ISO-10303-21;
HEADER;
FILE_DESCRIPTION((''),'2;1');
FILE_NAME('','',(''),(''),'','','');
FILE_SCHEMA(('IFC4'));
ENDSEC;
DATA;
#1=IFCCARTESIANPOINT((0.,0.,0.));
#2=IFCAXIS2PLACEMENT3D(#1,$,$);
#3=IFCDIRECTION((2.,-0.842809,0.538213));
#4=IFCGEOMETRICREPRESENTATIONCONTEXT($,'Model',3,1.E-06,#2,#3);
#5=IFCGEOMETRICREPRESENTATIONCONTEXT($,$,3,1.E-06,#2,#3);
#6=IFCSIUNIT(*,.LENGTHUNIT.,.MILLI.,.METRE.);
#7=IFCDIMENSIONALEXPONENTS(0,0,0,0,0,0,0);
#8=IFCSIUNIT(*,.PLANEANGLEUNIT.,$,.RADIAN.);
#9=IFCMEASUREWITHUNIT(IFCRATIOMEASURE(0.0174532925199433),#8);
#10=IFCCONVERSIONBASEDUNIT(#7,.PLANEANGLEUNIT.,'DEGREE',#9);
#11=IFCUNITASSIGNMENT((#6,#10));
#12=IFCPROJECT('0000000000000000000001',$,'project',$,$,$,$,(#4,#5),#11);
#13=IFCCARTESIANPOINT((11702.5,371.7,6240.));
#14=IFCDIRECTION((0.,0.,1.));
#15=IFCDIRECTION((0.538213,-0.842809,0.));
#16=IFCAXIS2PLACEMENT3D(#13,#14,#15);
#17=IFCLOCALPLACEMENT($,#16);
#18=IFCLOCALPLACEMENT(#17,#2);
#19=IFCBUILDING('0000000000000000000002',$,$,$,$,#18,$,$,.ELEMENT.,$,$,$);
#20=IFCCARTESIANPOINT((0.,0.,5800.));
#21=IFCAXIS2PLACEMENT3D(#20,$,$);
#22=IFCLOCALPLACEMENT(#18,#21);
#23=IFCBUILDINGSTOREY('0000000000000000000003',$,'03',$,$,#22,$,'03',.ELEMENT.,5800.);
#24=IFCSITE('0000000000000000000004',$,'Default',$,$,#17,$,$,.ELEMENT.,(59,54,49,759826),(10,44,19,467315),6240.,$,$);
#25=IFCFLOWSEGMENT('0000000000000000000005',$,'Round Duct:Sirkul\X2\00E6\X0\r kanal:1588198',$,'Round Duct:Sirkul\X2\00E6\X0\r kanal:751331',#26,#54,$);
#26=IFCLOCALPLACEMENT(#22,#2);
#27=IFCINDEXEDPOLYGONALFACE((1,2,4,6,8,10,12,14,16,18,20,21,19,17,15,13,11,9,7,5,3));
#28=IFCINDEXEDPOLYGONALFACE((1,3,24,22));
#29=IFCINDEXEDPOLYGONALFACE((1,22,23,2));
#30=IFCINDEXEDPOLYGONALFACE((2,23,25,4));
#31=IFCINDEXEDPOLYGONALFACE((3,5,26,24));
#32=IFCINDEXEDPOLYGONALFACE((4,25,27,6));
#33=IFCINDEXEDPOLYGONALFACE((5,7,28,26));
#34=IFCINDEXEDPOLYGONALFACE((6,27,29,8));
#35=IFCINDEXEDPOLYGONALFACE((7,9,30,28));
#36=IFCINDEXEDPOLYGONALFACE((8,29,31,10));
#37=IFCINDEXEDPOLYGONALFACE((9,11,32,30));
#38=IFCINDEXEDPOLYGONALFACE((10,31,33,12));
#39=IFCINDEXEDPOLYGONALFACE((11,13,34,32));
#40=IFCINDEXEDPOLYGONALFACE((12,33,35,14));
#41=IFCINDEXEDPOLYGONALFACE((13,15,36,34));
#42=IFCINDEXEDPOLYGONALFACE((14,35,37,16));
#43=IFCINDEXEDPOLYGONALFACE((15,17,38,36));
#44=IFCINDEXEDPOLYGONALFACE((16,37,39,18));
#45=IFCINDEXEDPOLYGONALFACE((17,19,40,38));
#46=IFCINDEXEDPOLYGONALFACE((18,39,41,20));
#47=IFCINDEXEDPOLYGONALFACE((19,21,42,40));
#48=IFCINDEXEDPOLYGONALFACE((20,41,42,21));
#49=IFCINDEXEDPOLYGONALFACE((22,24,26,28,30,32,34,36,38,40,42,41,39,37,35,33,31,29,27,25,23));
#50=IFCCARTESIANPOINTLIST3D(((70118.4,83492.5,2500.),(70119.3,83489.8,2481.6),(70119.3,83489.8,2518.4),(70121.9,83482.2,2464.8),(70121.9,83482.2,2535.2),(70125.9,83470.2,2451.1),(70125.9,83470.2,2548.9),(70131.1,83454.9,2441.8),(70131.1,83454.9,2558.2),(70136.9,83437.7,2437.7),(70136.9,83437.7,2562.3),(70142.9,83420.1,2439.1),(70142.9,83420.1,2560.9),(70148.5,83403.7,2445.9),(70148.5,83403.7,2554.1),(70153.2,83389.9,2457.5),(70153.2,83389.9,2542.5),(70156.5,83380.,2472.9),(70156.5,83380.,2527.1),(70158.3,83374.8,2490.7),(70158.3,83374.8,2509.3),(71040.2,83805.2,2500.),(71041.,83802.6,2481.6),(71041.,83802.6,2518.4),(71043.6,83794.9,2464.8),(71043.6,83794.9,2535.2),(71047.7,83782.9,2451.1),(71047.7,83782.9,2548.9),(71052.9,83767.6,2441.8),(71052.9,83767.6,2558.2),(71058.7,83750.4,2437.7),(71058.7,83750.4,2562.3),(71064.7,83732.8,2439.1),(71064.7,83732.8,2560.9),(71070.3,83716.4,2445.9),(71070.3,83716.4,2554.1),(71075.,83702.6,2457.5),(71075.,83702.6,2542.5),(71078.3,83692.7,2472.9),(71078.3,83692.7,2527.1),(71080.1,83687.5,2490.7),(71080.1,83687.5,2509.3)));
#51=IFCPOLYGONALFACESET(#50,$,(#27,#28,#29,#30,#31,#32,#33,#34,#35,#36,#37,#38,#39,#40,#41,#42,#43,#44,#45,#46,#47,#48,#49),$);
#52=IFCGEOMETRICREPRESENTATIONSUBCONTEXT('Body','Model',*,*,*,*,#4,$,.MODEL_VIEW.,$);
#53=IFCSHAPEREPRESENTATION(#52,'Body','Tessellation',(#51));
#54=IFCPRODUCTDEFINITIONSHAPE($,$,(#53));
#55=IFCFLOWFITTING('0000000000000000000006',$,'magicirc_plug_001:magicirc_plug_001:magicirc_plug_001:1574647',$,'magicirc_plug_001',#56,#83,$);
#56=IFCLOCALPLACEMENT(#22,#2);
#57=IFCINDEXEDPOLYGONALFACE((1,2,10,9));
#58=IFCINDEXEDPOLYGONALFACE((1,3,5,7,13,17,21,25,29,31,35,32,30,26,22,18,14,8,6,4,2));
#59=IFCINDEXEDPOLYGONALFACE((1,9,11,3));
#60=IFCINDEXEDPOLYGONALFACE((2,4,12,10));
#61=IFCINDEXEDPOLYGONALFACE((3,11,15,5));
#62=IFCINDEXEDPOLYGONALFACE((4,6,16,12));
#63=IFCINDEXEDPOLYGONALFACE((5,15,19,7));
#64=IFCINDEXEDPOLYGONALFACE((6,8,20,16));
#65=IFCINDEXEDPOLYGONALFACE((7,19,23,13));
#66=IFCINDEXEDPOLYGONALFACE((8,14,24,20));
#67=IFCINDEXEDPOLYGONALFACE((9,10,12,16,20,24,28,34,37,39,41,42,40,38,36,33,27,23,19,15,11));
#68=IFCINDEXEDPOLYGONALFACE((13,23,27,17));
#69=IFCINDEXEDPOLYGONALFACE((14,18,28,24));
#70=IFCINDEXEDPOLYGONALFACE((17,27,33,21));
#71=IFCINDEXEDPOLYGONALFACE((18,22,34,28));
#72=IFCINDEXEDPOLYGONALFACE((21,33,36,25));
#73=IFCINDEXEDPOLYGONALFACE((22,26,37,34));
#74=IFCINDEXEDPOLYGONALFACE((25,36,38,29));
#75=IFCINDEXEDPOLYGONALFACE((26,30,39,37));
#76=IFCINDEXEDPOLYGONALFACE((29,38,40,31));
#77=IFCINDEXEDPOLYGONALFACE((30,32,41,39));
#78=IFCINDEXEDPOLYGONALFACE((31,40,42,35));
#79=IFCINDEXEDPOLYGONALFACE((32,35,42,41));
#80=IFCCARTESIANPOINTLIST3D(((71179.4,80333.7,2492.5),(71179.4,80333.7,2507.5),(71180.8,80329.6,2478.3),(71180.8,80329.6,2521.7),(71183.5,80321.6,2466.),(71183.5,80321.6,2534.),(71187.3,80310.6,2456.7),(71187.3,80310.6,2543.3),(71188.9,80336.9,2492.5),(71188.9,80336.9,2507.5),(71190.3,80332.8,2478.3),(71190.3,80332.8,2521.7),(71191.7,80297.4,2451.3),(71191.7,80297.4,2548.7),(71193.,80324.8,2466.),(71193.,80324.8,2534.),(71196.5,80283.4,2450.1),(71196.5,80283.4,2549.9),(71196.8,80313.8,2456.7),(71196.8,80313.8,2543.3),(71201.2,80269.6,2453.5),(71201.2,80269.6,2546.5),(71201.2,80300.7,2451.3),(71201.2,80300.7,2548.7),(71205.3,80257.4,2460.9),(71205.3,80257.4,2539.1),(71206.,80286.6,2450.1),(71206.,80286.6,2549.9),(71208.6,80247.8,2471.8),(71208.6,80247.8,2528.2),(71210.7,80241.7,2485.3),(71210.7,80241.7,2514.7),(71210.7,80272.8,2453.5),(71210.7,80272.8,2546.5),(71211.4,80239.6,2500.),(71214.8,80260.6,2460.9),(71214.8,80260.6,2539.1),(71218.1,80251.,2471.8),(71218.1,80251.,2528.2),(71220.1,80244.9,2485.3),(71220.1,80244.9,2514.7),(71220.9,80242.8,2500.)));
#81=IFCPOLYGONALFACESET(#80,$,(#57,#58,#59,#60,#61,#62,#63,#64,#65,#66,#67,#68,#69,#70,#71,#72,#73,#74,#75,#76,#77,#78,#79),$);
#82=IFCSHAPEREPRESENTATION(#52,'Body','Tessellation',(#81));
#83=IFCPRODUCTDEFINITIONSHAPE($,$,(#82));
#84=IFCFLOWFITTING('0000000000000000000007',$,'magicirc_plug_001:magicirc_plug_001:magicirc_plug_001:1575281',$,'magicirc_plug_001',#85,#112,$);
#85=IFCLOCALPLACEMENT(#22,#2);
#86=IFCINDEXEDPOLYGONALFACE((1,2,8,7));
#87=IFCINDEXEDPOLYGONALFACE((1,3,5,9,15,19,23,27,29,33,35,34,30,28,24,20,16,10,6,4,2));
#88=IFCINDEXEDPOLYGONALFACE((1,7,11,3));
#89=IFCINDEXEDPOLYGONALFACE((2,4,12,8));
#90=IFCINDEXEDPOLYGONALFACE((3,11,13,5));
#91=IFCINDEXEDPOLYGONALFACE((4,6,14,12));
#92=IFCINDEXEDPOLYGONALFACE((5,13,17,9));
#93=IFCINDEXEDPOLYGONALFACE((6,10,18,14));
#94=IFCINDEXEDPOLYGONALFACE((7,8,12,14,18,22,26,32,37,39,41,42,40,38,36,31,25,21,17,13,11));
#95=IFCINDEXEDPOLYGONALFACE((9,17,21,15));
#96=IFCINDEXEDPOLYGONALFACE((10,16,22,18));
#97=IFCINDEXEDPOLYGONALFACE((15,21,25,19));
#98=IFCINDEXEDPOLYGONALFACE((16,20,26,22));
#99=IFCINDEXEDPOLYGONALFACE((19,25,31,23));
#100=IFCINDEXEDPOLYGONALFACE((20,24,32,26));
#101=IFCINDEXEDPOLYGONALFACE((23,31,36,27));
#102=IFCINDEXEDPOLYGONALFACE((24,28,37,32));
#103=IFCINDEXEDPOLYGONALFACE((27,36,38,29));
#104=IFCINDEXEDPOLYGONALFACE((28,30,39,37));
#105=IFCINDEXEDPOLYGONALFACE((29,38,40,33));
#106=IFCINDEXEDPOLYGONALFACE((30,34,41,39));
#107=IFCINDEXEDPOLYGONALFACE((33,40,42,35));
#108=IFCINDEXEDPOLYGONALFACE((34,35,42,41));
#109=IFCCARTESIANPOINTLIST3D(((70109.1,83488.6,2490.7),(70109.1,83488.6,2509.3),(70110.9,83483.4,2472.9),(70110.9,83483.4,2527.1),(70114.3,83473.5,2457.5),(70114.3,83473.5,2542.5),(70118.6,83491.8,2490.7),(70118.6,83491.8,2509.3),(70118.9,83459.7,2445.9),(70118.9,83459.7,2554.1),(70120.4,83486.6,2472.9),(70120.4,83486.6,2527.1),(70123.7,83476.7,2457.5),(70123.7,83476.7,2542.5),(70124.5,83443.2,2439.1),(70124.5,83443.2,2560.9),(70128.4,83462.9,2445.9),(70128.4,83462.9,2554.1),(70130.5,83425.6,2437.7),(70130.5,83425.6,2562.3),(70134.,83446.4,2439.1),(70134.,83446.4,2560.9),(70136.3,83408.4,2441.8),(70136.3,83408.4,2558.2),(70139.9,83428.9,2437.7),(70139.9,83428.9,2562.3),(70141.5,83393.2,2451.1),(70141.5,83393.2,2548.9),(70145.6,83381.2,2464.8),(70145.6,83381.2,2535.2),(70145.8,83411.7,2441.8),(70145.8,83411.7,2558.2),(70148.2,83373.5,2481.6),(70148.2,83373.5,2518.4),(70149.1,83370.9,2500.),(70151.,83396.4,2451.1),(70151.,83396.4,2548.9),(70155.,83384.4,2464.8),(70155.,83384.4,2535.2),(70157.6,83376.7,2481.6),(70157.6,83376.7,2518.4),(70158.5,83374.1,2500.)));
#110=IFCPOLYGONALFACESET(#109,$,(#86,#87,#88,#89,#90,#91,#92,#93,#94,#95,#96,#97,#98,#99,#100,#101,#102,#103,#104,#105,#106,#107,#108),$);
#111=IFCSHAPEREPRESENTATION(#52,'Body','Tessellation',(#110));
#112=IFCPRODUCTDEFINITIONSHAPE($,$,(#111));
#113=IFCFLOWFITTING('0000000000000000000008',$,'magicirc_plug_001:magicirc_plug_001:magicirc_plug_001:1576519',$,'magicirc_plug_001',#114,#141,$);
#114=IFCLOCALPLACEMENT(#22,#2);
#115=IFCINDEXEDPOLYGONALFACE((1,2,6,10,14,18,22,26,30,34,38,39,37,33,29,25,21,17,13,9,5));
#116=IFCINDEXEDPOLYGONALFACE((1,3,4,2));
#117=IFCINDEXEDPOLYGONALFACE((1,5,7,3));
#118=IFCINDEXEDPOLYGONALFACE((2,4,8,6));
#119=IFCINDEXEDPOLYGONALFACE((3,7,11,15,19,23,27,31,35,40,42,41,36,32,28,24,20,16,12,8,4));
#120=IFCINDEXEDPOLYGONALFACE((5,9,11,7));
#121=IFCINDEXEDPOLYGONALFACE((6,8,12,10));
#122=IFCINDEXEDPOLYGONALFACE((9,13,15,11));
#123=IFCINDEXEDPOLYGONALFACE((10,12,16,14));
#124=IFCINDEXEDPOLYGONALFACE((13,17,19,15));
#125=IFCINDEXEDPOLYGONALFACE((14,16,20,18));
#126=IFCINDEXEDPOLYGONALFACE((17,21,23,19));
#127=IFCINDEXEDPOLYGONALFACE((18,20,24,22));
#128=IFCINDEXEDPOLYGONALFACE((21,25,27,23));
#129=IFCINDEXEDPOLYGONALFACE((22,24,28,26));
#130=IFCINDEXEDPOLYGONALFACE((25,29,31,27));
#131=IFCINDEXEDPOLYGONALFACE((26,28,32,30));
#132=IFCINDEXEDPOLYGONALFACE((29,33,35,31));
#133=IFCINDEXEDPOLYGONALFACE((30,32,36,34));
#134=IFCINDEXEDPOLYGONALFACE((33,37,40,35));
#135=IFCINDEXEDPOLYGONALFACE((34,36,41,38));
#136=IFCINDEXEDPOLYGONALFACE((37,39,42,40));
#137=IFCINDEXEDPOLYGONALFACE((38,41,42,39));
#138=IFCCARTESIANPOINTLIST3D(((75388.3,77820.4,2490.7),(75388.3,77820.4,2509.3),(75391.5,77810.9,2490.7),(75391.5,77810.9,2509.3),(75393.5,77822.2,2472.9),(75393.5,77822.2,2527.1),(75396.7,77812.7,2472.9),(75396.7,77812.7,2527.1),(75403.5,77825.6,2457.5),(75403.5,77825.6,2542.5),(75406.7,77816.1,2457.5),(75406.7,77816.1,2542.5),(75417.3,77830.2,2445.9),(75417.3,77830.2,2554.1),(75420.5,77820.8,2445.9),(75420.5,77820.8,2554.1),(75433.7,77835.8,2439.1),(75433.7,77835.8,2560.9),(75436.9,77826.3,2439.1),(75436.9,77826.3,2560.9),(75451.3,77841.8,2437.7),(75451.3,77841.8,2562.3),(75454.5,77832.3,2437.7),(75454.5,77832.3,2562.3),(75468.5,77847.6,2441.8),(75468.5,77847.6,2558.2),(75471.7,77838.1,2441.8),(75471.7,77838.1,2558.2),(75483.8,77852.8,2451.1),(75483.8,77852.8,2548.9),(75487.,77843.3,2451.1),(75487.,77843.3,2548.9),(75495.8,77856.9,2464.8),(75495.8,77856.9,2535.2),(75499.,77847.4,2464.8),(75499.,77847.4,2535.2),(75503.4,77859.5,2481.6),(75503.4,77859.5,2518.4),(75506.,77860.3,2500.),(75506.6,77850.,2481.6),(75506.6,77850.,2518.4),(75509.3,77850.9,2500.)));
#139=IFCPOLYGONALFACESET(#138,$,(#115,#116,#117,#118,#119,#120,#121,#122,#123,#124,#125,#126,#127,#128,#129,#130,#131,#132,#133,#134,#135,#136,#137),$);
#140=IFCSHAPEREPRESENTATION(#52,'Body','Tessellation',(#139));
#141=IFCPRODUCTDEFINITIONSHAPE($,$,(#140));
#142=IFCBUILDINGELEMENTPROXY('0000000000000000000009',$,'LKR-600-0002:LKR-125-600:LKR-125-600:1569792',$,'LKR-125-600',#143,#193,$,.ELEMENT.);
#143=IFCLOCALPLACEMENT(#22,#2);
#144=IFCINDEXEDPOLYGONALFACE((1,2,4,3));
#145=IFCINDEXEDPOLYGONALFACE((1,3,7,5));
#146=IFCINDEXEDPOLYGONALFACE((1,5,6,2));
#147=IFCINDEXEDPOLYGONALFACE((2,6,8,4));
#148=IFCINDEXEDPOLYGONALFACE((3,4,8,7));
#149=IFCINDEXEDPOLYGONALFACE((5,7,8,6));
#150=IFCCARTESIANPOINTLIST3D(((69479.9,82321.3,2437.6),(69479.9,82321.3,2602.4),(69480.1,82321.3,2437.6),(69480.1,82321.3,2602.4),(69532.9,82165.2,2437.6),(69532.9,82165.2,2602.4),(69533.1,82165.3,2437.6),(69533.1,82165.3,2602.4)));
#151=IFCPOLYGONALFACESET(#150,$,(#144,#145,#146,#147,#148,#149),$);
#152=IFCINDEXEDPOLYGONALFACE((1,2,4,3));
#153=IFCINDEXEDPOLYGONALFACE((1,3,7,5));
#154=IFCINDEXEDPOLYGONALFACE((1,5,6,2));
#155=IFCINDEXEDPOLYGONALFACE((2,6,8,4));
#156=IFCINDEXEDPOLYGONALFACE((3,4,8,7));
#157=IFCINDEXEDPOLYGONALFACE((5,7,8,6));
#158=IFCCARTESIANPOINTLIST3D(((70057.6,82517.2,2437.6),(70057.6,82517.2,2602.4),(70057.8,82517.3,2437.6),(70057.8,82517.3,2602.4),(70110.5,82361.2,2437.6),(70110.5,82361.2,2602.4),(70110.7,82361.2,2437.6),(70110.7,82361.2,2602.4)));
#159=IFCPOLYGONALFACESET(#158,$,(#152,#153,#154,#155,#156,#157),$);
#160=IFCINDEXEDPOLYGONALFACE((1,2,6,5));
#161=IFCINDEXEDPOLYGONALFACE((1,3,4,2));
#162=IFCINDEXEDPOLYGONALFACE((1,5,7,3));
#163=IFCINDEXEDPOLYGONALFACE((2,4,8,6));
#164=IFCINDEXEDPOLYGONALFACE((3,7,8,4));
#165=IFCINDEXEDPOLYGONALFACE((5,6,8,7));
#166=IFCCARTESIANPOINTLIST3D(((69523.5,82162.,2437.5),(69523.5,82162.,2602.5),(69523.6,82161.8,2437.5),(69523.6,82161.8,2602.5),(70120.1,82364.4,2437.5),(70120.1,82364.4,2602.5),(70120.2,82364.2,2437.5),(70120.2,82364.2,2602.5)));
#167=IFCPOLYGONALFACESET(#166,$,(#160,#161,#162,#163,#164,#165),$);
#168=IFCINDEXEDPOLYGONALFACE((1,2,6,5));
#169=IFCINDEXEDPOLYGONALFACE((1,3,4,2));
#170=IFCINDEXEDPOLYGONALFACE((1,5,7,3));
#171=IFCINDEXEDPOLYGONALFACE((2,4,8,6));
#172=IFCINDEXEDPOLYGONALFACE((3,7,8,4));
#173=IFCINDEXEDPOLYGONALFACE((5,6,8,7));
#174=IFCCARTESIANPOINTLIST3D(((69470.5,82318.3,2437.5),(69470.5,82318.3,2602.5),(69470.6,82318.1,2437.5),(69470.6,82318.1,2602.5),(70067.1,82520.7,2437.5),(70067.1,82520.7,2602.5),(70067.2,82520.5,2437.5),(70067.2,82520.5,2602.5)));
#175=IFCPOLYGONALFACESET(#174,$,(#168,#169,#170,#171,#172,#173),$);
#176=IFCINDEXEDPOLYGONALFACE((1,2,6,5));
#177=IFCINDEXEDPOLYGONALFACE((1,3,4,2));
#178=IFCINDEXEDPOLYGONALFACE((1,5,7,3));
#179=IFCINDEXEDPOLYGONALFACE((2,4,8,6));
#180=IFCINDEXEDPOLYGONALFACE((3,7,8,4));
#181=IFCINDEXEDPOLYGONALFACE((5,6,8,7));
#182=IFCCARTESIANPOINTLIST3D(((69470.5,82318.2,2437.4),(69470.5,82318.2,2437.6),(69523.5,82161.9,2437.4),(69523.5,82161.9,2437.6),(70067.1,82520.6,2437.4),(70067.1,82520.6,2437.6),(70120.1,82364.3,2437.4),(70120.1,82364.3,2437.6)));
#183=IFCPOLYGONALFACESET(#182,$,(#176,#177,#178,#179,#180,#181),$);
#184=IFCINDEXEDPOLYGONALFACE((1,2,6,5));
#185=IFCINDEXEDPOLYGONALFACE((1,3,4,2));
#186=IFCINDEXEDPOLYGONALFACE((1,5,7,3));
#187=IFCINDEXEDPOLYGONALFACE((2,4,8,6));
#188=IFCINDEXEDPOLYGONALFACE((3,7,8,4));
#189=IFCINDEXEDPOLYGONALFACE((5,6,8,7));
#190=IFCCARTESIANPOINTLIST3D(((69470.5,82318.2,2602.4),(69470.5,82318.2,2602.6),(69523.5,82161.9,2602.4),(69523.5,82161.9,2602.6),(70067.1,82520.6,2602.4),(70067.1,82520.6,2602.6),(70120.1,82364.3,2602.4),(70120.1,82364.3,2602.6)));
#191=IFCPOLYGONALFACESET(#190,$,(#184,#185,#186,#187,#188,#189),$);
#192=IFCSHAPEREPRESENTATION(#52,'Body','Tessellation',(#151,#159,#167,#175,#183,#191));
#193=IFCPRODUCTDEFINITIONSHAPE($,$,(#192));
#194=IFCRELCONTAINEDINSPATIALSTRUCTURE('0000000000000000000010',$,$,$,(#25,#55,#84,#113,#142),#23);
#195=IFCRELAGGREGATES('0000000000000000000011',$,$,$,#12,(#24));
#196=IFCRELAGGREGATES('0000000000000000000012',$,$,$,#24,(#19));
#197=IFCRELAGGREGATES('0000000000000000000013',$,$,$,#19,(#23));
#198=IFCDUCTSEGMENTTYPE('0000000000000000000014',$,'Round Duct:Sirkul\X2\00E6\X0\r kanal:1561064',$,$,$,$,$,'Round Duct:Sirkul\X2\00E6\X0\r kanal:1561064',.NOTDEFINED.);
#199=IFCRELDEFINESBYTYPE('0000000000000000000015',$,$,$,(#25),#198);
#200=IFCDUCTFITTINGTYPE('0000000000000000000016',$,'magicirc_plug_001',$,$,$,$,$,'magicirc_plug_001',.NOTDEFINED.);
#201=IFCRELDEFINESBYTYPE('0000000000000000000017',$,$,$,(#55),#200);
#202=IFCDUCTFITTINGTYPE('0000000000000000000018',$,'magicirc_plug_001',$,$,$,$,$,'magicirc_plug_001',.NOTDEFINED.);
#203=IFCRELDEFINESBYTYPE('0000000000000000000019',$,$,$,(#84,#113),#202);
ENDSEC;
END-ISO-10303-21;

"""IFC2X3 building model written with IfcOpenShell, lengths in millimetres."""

from ifc_helpers import new_model, entity, si_unit, converted_unit, direction, frame, frame_2d, origin, place, context, subcontext, project, spatial, rectangle, circle, extrude, source, transform, mapped, type_object, type_shapes, element, save


model = new_model("IFC2X3")

# Units and contexts
model_context = context("Model", 3, precision=1e-06, world=origin(), true_north=direction((2.0, -0.842809, 0.538213)))
context_of_model = context(None, 3, precision=1e-06, world=origin(), true_north=direction((2.0, -0.842809, 0.538213)))
body_context = subcontext(model_context, "Body", "Model", "MODEL_VIEW")
ifc_project = project(units=[si_unit("LENGTHUNIT", "METRE", prefix="MILLI"), converted_unit("PLANEANGLEUNIT", "DEGREE", entity("IfcRatioMeasure", 0.0174532925199433), si_unit("PLANEANGLEUNIT", "RADIAN"), dimensions=[0, 0, 0, 0, 0, 0, 0])], contexts=[model_context, context_of_model])

# Site, building, storey
site_placement = place(None, frame((11702.5, 371.7, 6240.0), z_axis=(0.0, 0.0, 1.0), x_axis=(0.538213, -0.842809, 0.0)))
site = spatial("IfcSite", under=ifc_project, at=site_placement, Name="Default", CompositionType="ELEMENT", RefLatitude=(59, 54, 49, 759826), RefLongitude=(10, 44, 19, 467315), RefElevation=6240.0)
building_placement = place(site_placement, origin())
building = spatial("IfcBuilding", under=site, at=building_placement, CompositionType="ELEMENT")
storey_placement = place(building_placement, frame((0.0, 0.0, 5800.0)))
storey = spatial("IfcBuildingStorey", under=building, at=storey_placement, Name="03", LongName="03", CompositionType="ELEMENT", Elevation=5800.0)

# Flow segment
duct_segment_type = type_object("IfcDuctSegmentType", Name="Round Duct:Sirkulær kanal:1561064", ElementType="Round Duct:Sirkulær kanal:1561064", PredefinedType="NOTDEFINED")
flow_segment_1_placement = place(storey_placement, origin())
element("IfcFlowSegment", 1, at=flow_segment_1_placement, inside=storey, type_object=duct_segment_type, Name="Round Duct:Sirkulær kanal:1588198", ObjectType="Round Duct:Sirkulær kanal:751331", context=body_context, shape_type="SweptSolid", body=[
    extrude(circle(Radius=62.5, at=frame_2d((0.0, 0.0), x_axis=(1.0, 0.0))), frame((70138.4, 83433.3, 2500.0), z_axis=(0.946986, 0.321274, 0.0), x_axis=(-0.321274, 0.946986, 0.0)), (0.0, 0.0, 1.0), 973.4),
])

# Flow fittings
duct_fitting_type_1 = type_object("IfcDuctFittingType", Name="magicirc_plug_001", ElementType="magicirc_plug_001", PredefinedType="NOTDEFINED")
shared_shape_1 = source(origin(), body_context, "Body", "SweptSolid", [
    extrude(circle(Radius=50.0, at=frame_2d((0.0, 0.0), x_axis=(1.0, 0.0))), frame((0.0, 0.0, 0.0), z_axis=(1.0, 0.0, 0.0), x_axis=(0.0, 1.0, 0.0)), (0.0, 0.0, 1.0), 10.0),
])
type_shapes(duct_fitting_type_1, [shared_shape_1])
flow_fitting_placement = place(storey_placement, frame((71204.8, 80290.1, 2500.0), z_axis=(0.0, 0.0, 1.0), x_axis=(-0.946986, -0.321274, 0.0)))
element("IfcFlowFitting", 2, at=flow_fitting_placement, inside=storey, type_object=duct_fitting_type_1, Name="magicirc_plug_001:magicirc_plug_001:magicirc_plug_001:1574647", ObjectType="magicirc_plug_001", context=body_context, shape_type="MappedRepresentation", body=[
    mapped(shared_shape_1, transform((0.0, 0.0, 0.0), scale=1.0)),
])
duct_fitting_type_2 = type_object("IfcDuctFittingType", Name="magicirc_plug_001", ElementType="magicirc_plug_001", PredefinedType="NOTDEFINED")
shared_shape_2 = source(origin(), body_context, "Body", "SweptSolid", [
    extrude(circle(Radius=62.5, at=frame_2d((0.0, 0.0), x_axis=(1.0, 0.0))), frame((0.0, 0.0, 0.0), z_axis=(1.0, 0.0, 0.0), x_axis=(0.0, 1.0, 0.0)), (0.0, 0.0, 1.0), 10.0),
])
type_shapes(duct_fitting_type_2, [shared_shape_2])
for number, where, z_axis, x_axis, name in (
    (3, (70138.4, 83433.3, 2500.0), (0.0, 0.0, 1.0), (-0.946986, -0.321274, 0.0), "magicirc_plug_001:magicirc_plug_001:magicirc_plug_001:1575281"),
    (4, (75446.9, 77840.3, 2500.0), (0.0, 0.0, 1.0), (0.321274, -0.946986, 0.0), "magicirc_plug_001:magicirc_plug_001:magicirc_plug_001:1576519"),
):
    element("IfcFlowFitting", number, at=place(storey_placement, frame(where, z_axis=z_axis, x_axis=x_axis)), inside=storey, type_object=duct_fitting_type_2, Name=name, ObjectType="magicirc_plug_001", context=body_context, shape_type="MappedRepresentation", body=[
        mapped(shared_shape_2, transform((0.0, 0.0, 0.0), scale=1.0)),
    ])

# Building element proxy
shared_shape_3 = source(origin(), body_context, "Body", "SweptSolid", [
    extrude(rectangle(XDim=0.2, YDim=164.8, at=frame_2d((0.0, 0.0), x_axis=(1.0, 0.0))), frame((305.0, 0.0, -82.4)), (0.0, 0.0, 1.0), 164.8),
    extrude(rectangle(XDim=0.2, YDim=164.8, at=frame_2d((0.0, 0.0), x_axis=(1.0, 0.0))), frame((-305.0, 0.0, -82.4)), (0.0, 0.0, 1.0), 164.8),
    extrude(rectangle(XDim=0.2, YDim=630.0, at=frame_2d((0.0, 0.0), x_axis=(1.0, 0.0))), frame((0.0, 82.5, -82.5), z_axis=(0.0, 0.0, 1.0), x_axis=(0.0, 1.0, 0.0)), (0.0, 0.0, 1.0), 165.0),
    extrude(rectangle(XDim=0.2, YDim=630.0, at=frame_2d((0.0, 0.0), x_axis=(1.0, 0.0))), frame((0.0, -82.5, -82.5), z_axis=(0.0, 0.0, 1.0), x_axis=(0.0, 1.0, 0.0)), (0.0, 0.0, 1.0), 165.0),
    extrude(rectangle(XDim=165.0, YDim=630.0, at=frame_2d((0.0, 0.0), x_axis=(1.0, 0.0))), frame((0.0, 0.0, -82.6), z_axis=(0.0, 0.0, 1.0), x_axis=(0.0, -1.0, 0.0)), (0.0, 0.0, 1.0), 0.2),
    extrude(rectangle(XDim=165.0, YDim=630.0, at=frame_2d((0.0, 0.0), x_axis=(1.0, 0.0))), frame((0.0, 0.0, 82.4), z_axis=(0.0, 0.0, 1.0), x_axis=(0.0, -1.0, 0.0)), (0.0, 0.0, 1.0), 0.2),
])
for number, where, z_axis, x_axis, name in (
    (5, (69795.3, 82341.3, 2520.0), (0.0, 0.0, 1.0), (-0.946986, -0.321274, 0.0), "LKR-600-0002:LKR-125-600:LKR-125-600:1569792"),
):
    element("IfcBuildingElementProxy", number, at=place(storey_placement, frame(where, z_axis=z_axis, x_axis=x_axis)), inside=storey, Name=name, ObjectType="LKR-125-600", CompositionType="ELEMENT", context=body_context, shape_type="MappedRepresentation", body=[
        mapped(shared_shape_3, transform((0.0, 0.0, 0.0), scale=1.0)),
    ])

save(model, "model.ifc")
